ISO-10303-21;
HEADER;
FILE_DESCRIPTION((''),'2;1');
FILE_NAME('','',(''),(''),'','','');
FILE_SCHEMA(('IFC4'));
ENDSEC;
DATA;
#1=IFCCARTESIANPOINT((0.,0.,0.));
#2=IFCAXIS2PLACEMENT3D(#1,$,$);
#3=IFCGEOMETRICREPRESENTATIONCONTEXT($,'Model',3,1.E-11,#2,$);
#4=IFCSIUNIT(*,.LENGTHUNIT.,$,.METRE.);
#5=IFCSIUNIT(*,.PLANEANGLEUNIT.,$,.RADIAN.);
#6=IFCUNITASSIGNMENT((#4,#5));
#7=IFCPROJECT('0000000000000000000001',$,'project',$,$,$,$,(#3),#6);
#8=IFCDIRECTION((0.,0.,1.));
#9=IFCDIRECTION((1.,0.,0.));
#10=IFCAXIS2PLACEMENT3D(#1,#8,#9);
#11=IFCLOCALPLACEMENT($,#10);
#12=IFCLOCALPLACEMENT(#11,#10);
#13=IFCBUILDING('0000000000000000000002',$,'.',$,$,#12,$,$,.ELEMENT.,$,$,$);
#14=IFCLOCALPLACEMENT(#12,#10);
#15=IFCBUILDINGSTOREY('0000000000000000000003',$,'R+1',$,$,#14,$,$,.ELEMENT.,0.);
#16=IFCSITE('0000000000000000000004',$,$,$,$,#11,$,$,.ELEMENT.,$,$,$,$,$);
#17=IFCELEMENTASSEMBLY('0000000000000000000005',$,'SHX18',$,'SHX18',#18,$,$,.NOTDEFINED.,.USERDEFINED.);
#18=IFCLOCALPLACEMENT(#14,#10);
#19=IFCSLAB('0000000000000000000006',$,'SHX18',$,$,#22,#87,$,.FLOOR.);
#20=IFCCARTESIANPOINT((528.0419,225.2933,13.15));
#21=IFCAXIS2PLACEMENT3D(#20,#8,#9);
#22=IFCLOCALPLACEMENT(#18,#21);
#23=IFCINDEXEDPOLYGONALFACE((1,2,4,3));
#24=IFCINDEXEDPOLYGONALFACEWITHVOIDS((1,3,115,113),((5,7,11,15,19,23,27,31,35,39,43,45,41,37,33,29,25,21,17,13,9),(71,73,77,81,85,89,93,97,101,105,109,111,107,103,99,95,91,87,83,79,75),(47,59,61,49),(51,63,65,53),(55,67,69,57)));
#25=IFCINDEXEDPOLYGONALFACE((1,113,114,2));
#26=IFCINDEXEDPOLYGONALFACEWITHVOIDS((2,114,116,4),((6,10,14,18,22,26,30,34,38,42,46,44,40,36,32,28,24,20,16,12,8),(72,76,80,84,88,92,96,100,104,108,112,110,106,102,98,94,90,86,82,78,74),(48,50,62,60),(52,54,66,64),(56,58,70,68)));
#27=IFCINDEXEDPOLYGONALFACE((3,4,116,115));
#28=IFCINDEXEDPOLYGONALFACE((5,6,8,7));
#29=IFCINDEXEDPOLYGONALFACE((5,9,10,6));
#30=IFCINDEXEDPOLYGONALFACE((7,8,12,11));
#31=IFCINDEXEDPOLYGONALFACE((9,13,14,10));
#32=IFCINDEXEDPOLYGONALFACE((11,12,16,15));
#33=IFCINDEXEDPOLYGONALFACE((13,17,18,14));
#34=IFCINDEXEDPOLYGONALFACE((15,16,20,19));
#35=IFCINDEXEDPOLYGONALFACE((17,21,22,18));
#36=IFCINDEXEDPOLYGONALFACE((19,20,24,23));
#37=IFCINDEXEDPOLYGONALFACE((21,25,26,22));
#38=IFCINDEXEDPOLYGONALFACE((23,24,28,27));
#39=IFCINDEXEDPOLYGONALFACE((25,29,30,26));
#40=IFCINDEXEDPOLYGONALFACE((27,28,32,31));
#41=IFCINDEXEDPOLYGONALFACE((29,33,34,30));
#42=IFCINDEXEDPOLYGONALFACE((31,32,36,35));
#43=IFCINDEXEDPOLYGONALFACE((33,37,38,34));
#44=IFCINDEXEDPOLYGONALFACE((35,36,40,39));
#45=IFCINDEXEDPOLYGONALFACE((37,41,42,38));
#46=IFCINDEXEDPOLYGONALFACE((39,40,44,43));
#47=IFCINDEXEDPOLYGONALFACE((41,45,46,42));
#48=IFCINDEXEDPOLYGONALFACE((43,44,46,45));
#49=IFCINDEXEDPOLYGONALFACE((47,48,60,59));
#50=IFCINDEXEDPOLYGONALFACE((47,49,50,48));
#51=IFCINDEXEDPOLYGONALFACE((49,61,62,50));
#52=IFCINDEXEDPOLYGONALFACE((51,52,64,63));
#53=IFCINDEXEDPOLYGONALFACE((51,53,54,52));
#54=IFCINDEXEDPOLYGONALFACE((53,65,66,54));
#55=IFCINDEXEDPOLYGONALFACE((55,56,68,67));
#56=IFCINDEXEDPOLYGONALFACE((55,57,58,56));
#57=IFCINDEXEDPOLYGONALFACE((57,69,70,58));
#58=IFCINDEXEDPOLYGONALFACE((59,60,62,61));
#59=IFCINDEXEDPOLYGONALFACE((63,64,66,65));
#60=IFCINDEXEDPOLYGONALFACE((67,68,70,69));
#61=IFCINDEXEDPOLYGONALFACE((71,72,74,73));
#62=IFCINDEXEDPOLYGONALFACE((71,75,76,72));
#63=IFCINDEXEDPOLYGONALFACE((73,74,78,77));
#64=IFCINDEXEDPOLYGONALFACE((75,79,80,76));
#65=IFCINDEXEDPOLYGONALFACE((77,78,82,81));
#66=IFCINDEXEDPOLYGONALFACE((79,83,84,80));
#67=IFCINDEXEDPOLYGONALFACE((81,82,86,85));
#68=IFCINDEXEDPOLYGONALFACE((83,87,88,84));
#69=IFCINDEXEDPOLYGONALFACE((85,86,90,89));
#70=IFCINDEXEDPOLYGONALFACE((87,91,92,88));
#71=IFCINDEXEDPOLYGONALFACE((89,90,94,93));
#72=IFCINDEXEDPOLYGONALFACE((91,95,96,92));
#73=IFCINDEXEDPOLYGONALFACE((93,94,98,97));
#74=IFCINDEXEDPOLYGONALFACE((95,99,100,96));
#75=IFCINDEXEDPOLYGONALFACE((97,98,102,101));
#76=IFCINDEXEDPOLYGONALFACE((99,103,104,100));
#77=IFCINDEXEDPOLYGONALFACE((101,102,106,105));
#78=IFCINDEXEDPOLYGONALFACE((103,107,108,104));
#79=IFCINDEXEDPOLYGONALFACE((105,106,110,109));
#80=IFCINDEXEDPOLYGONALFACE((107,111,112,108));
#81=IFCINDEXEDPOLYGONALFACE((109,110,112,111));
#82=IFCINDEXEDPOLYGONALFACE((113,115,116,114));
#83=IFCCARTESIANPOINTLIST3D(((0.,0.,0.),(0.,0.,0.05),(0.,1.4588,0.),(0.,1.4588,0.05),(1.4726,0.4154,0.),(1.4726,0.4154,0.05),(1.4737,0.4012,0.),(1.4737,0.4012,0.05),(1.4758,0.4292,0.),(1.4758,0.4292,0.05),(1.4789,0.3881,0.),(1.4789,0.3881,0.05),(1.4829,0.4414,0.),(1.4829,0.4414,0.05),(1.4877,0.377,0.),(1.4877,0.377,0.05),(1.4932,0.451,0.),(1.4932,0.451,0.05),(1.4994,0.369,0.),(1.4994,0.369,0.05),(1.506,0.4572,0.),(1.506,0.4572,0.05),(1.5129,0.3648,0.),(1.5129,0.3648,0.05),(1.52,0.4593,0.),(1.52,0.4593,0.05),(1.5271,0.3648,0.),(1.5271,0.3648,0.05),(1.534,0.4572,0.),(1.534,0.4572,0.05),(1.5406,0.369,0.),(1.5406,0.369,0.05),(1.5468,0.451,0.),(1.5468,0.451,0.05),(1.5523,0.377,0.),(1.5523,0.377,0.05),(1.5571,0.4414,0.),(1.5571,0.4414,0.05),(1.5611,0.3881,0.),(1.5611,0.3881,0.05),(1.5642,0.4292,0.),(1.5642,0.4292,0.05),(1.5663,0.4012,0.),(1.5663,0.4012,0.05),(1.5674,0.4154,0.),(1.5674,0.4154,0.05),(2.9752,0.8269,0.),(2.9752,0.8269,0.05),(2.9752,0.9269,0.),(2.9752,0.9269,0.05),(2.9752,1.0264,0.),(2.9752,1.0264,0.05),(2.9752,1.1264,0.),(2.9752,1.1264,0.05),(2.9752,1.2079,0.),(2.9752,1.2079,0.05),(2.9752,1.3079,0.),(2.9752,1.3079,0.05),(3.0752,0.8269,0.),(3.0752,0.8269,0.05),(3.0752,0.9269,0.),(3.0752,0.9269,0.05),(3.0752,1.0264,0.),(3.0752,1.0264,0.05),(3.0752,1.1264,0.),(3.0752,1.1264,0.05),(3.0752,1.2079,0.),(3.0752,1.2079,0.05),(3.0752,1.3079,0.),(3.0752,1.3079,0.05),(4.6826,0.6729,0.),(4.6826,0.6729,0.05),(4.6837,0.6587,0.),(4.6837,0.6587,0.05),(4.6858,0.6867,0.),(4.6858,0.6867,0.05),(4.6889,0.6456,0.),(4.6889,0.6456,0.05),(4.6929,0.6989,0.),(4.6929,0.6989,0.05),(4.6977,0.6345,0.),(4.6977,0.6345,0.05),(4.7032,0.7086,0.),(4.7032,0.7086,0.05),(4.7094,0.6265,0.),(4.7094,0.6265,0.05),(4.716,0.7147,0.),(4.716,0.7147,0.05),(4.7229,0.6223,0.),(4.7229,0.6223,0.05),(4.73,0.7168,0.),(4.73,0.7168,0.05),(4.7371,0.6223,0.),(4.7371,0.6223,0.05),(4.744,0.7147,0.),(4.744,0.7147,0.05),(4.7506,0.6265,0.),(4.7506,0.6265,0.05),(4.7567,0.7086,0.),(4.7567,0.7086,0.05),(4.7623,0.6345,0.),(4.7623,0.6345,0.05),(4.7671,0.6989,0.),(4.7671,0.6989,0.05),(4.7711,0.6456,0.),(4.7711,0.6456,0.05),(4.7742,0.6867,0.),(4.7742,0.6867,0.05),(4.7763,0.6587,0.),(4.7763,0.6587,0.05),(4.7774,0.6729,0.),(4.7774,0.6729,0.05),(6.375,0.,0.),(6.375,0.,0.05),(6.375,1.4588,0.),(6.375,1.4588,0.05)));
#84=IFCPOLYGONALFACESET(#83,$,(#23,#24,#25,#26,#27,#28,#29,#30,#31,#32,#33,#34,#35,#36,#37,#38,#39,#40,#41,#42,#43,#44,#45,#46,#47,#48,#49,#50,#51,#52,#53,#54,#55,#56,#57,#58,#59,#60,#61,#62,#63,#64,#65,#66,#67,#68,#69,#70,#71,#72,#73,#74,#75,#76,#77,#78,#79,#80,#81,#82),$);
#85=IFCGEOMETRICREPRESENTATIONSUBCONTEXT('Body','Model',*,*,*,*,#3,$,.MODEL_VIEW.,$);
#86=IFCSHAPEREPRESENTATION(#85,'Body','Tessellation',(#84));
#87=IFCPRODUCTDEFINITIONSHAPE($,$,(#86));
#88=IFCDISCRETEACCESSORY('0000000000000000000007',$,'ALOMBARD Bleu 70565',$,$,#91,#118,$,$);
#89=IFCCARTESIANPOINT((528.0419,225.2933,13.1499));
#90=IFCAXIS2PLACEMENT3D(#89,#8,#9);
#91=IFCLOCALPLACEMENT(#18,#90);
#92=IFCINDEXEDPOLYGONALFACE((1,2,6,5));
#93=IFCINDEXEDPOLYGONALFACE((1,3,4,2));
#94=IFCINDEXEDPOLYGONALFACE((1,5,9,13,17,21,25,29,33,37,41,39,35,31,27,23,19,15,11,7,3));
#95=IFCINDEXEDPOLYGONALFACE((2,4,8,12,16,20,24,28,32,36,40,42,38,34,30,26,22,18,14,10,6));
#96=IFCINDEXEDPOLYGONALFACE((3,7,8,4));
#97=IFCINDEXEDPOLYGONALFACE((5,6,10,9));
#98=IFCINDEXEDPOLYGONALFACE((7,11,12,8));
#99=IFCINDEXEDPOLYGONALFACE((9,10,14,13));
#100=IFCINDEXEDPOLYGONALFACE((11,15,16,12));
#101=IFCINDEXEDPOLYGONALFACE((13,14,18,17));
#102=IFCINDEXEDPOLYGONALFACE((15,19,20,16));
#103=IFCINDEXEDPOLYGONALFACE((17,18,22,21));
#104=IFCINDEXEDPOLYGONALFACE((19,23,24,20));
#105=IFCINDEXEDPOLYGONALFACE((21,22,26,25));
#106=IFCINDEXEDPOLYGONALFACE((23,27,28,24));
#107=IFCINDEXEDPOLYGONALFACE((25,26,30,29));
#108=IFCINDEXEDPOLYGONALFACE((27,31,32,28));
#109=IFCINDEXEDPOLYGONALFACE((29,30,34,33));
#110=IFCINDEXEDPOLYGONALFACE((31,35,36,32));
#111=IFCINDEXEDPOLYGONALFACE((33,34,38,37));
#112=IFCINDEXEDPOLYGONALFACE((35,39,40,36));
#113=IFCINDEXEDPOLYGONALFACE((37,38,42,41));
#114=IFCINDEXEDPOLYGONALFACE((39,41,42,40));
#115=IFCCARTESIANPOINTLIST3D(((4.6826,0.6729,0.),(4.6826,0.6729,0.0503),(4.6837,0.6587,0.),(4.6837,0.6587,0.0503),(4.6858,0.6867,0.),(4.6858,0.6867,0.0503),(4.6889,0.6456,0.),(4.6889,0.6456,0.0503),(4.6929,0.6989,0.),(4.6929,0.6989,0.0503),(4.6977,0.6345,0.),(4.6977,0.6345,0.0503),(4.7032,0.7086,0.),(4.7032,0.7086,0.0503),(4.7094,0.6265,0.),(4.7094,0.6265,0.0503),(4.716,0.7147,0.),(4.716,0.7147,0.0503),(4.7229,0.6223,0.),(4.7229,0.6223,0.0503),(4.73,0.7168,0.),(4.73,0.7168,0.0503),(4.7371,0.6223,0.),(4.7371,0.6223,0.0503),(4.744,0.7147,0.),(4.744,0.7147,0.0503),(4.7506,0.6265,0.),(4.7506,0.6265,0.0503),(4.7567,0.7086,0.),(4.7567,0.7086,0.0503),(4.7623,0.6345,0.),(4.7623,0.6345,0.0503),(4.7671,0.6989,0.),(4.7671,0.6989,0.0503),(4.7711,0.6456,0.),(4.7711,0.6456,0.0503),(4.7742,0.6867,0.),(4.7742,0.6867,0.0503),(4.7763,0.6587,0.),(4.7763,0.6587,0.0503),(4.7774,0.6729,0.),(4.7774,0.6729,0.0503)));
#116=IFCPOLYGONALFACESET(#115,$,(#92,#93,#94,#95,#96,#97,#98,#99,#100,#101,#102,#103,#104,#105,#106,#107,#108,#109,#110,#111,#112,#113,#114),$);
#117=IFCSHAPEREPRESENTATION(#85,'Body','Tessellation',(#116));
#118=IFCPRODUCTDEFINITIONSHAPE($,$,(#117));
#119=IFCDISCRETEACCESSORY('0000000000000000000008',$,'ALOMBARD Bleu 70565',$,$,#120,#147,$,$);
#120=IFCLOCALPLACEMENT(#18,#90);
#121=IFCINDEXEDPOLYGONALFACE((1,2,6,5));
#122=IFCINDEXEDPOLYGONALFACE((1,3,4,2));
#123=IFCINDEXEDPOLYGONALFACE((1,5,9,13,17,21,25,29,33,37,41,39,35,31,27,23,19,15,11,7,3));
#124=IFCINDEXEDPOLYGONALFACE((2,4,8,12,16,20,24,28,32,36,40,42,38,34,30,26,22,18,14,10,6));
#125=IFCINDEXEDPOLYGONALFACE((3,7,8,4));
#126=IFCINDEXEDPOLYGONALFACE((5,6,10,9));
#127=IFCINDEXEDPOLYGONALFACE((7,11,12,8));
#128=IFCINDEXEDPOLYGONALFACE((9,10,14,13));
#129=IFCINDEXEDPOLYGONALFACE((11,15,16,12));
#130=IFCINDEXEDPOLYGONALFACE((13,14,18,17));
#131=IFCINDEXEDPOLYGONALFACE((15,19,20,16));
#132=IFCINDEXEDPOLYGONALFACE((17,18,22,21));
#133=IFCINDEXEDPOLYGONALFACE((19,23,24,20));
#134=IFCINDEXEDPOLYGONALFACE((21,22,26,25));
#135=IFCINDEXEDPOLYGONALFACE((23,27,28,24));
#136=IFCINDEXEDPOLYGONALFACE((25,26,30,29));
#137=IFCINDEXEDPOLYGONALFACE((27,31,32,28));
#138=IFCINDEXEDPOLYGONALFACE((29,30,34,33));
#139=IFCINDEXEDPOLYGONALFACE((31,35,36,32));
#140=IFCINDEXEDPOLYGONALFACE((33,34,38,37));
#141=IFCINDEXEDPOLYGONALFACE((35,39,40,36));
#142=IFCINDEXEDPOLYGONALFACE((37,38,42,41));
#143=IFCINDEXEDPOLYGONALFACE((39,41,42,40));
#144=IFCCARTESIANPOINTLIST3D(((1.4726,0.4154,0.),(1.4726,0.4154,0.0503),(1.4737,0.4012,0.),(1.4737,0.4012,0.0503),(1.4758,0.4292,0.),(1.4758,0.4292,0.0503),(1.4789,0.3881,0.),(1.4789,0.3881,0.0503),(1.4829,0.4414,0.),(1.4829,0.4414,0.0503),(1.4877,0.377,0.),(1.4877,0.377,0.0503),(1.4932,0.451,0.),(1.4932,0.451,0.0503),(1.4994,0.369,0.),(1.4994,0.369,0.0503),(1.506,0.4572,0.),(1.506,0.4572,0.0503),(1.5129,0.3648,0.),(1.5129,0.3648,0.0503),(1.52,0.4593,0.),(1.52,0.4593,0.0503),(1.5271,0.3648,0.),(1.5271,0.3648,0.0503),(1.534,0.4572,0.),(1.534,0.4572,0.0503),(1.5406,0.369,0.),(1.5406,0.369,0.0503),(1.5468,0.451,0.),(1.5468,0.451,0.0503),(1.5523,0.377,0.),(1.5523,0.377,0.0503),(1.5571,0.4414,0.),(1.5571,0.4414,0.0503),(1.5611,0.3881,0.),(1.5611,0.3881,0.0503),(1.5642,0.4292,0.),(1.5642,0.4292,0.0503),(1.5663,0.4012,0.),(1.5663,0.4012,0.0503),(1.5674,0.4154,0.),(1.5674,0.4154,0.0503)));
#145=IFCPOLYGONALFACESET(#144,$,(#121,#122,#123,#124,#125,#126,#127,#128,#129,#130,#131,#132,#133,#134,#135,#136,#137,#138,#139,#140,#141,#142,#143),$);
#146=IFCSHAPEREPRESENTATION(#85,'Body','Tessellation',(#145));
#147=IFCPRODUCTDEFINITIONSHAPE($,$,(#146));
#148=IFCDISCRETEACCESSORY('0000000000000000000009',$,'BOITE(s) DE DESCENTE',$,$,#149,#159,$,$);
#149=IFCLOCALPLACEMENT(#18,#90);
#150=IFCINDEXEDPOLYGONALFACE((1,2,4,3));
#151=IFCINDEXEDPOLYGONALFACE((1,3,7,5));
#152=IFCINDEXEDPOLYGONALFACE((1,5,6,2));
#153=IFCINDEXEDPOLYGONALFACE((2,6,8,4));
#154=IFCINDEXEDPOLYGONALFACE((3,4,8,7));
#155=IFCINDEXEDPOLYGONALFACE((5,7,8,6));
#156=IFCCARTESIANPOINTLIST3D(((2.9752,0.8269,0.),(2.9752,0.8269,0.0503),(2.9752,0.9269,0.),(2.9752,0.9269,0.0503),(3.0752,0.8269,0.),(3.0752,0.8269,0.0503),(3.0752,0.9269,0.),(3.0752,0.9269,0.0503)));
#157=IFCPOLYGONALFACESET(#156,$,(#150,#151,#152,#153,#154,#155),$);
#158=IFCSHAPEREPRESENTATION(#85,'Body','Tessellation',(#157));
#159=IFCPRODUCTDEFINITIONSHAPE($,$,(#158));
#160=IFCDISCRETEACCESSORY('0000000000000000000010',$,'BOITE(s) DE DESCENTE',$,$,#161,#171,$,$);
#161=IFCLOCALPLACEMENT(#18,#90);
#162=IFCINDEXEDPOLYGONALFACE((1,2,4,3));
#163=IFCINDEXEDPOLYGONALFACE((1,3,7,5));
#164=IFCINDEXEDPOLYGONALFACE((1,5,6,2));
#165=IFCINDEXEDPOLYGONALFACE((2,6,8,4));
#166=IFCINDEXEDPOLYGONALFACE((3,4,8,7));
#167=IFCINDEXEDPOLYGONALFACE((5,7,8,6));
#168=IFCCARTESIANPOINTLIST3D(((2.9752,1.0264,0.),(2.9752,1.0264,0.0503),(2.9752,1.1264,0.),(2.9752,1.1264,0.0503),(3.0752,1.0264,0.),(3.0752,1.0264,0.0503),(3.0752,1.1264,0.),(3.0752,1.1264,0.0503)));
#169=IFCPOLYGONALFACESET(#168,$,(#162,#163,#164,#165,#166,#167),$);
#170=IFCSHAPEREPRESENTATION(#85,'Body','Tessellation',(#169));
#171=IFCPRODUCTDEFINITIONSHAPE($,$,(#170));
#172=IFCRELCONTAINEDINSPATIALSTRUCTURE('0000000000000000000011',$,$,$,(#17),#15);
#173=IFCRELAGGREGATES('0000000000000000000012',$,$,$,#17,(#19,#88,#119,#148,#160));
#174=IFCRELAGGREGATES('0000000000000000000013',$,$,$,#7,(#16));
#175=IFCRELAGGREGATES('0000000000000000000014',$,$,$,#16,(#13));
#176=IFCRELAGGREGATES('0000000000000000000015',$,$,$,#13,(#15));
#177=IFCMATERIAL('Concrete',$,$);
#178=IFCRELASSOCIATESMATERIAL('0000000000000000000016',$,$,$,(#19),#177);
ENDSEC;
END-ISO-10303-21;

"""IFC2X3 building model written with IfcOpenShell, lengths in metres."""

from ifc_helpers import new_model, si_unit, frame, frame_2d, origin, origin_with_axes, origin_2d_with_axis, place, context, subcontext, project, spatial, polyline, circle, outline, extrude, material, element, aggregate, save


model = new_model("IFC2X3")

# Units and contexts
model_context = context("Model", 3, precision=1e-11, world=origin())
body_context = subcontext(model_context, "Body", "Model", "MODEL_VIEW")
ifc_project = project(units=[si_unit("LENGTHUNIT", "METRE"), si_unit("PLANEANGLEUNIT", "RADIAN")], contexts=[model_context])

# Site, building, storey
site_placement = place(None, origin_with_axes())
site = spatial("IfcSite", under=ifc_project, at=site_placement, CompositionType="ELEMENT")
building_placement = place(site_placement, origin_with_axes())
building = spatial("IfcBuilding", under=site, at=building_placement, Name=".", CompositionType="ELEMENT")
storey_placement = place(building_placement, origin_with_axes())
storey = spatial("IfcBuildingStorey", under=building, at=storey_placement, Name="R+1", CompositionType="ELEMENT", Elevation=0.0)

# Element assembly, slab, openings
assembly_1_placement = place(storey_placement, origin_with_axes())
assembly_1 = element("IfcElementAssembly", 1, at=assembly_1_placement, inside=storey, Name="SHX18", ObjectType="SHX18", AssemblyPlace="NOTDEFINED", PredefinedType="USERDEFINED")
ifc_material = material(Name="Concrete")
slab_1_placement = place(assembly_1_placement, frame((528.0419, 225.2933, 13.15), z_axis=(0.0, 0.0, 1.0), x_axis=(1.0, 0.0, 0.0)))
slab_1 = element("IfcSlab", 2, at=slab_1_placement, material=ifc_material, Name="SHX18", PredefinedType="FLOOR", context=body_context, shape_type="SweptSolid", body=[
    extrude(outline(polyline([(0.0, 0.0), (0.0, -6.375), (1.4588, -6.375), (1.4588, 0.0), (0.0, 0.0)])), frame((0.0, 0.0, 0.0), z_axis=(0.0, 0.0, 1.0), x_axis=(0.0, 1.0, 0.0)), (0.0, 0.0, 1.0), 0.05),
])
opening_1_placement = place(slab_1_placement, frame((4.73, 0.6693, 0.0), z_axis=(0.0, 0.0, 1.0), x_axis=(1.0, 0.0, 0.0)))
element("IfcOpeningElement", 3, at=opening_1_placement, cuts=slab_1, ObjectType="Opening", context=body_context, shape_type="SweptSolid", body=[
    extrude(circle(Radius=0.0475, at=origin_2d_with_axis()), frame((0.0, 0.0, 0.0), z_axis=(0.0, 0.0, 1.0), x_axis=(0.0, 1.0, 0.0)), (0.0, 0.0, 1.0), 0.05),
])
opening_2_placement = place(slab_1_placement, frame((1.52, 0.4118, 0.0), z_axis=(0.0, 0.0, 1.0), x_axis=(1.0, 0.0, 0.0)))
element("IfcOpeningElement", 4, at=opening_2_placement, cuts=slab_1, ObjectType="Opening", context=body_context, shape_type="SweptSolid", body=[
    extrude(circle(Radius=0.0475, at=origin_2d_with_axis()), frame((0.0, 0.0, 0.0), z_axis=(0.0, 0.0, 1.0), x_axis=(0.0, 1.0, 0.0)), (0.0, 0.0, 1.0), 0.05),
])
opening_3_placement = place(slab_1_placement, origin_with_axes())
element("IfcOpeningElement", 5, at=opening_3_placement, cuts=slab_1, ObjectType="Opening", context=body_context, shape_type="SweptSolid", body=[
    extrude(outline(polyline([(0.8269, -2.9752), (0.8269, -3.0752), (0.9269, -3.0752), (0.9269, -2.9752), (0.8269, -2.9752)])), frame((0.0, 0.0, 0.0), z_axis=(0.0, 0.0, 1.0), x_axis=(0.0, 1.0, 0.0)), (0.0, 0.0, 1.0), 0.05),
])
opening_4_placement = place(slab_1_placement, origin_with_axes())
element("IfcOpeningElement", 6, at=opening_4_placement, cuts=slab_1, ObjectType="Opening", context=body_context, shape_type="SweptSolid", body=[
    extrude(outline(polyline([(1.0264, -2.9752), (1.0264, -3.0752), (1.1264, -3.0752), (1.1264, -2.9752), (1.0264, -2.9752)])), frame((0.0, 0.0, 0.0), z_axis=(0.0, 0.0, 1.0), x_axis=(0.0, 1.0, 0.0)), (0.0, 0.0, 1.0), 0.05),
])
opening_5_placement = place(slab_1_placement, origin_with_axes())
element("IfcOpeningElement", 7, at=opening_5_placement, cuts=slab_1, ObjectType="Opening", context=body_context, shape_type="SweptSolid", body=[
    extrude(outline(polyline([(1.2079, -2.9752), (1.2079, -3.0752), (1.3079, -3.0752), (1.3079, -2.9752), (1.2079, -2.9752)])), frame((0.0, 0.0, 0.0), z_axis=(0.0, 0.0, 1.0), x_axis=(0.0, 1.0, 0.0)), (0.0, 0.0, 1.0), 0.05),
])

# Discrete accessories
discrete_accessory_1_placement = place(assembly_1_placement, frame((528.0419, 225.2933, 13.1499), z_axis=(0.0, 0.0, 1.0), x_axis=(1.0, 0.0, 0.0)))
discrete_accessory_1 = element("IfcDiscreteAccessory", 8, at=discrete_accessory_1_placement, Name="ALOMBARD Bleu 70565", context=body_context, shape_type="SweptSolid", body=[
    extrude(circle(Radius=0.0475, at=frame_2d((0.6693, -4.73), x_axis=(1.0, 0.0))), frame((0.0, 0.0, 0.0), z_axis=(0.0, 0.0, 1.0), x_axis=(0.0, 1.0, 0.0)), (0.0, 0.0, 1.0), 0.0503),
])
discrete_accessory_2_placement = place(assembly_1_placement, frame((528.0419, 225.2933, 13.1499), z_axis=(0.0, 0.0, 1.0), x_axis=(1.0, 0.0, 0.0)))
discrete_accessory_2 = element("IfcDiscreteAccessory", 9, at=discrete_accessory_2_placement, Name="ALOMBARD Bleu 70565", context=body_context, shape_type="SweptSolid", body=[
    extrude(circle(Radius=0.0475, at=frame_2d((0.4118, -1.52), x_axis=(1.0, 0.0))), frame((0.0, 0.0, 0.0), z_axis=(0.0, 0.0, 1.0), x_axis=(0.0, 1.0, 0.0)), (0.0, 0.0, 1.0), 0.0503),
])
discrete_accessory_3_placement = place(assembly_1_placement, frame((528.0419, 225.2933, 13.1499), z_axis=(0.0, 0.0, 1.0), x_axis=(1.0, 0.0, 0.0)))
discrete_accessory_3 = element("IfcDiscreteAccessory", 10, at=discrete_accessory_3_placement, Name="BOITE(s) DE DESCENTE", context=body_context, shape_type="SweptSolid", body=[
    extrude(outline(polyline([(0.8269, -2.9752), (0.8269, -3.0752), (0.9269, -3.0752), (0.9269, -2.9752), (0.8269, -2.9752)])), frame((0.0, 0.0, 0.0), z_axis=(0.0, 0.0, 1.0), x_axis=(0.0, 1.0, 0.0)), (0.0, 0.0, 1.0), 0.0503),
])
discrete_accessory_4_placement = place(assembly_1_placement, frame((528.0419, 225.2933, 13.1499), z_axis=(0.0, 0.0, 1.0), x_axis=(1.0, 0.0, 0.0)))
discrete_accessory_4 = element("IfcDiscreteAccessory", 11, at=discrete_accessory_4_placement, Name="BOITE(s) DE DESCENTE", context=body_context, shape_type="SweptSolid", body=[
    extrude(outline(polyline([(1.0264, -2.9752), (1.0264, -3.0752), (1.1264, -3.0752), (1.1264, -2.9752), (1.0264, -2.9752)])), frame((0.0, 0.0, 0.0), z_axis=(0.0, 0.0, 1.0), x_axis=(0.0, 1.0, 0.0)), (0.0, 0.0, 1.0), 0.0503),
])

aggregate(assembly_1, [slab_1, discrete_accessory_1, discrete_accessory_2, discrete_accessory_3, discrete_accessory_4])

save(model, "model.ifc")
